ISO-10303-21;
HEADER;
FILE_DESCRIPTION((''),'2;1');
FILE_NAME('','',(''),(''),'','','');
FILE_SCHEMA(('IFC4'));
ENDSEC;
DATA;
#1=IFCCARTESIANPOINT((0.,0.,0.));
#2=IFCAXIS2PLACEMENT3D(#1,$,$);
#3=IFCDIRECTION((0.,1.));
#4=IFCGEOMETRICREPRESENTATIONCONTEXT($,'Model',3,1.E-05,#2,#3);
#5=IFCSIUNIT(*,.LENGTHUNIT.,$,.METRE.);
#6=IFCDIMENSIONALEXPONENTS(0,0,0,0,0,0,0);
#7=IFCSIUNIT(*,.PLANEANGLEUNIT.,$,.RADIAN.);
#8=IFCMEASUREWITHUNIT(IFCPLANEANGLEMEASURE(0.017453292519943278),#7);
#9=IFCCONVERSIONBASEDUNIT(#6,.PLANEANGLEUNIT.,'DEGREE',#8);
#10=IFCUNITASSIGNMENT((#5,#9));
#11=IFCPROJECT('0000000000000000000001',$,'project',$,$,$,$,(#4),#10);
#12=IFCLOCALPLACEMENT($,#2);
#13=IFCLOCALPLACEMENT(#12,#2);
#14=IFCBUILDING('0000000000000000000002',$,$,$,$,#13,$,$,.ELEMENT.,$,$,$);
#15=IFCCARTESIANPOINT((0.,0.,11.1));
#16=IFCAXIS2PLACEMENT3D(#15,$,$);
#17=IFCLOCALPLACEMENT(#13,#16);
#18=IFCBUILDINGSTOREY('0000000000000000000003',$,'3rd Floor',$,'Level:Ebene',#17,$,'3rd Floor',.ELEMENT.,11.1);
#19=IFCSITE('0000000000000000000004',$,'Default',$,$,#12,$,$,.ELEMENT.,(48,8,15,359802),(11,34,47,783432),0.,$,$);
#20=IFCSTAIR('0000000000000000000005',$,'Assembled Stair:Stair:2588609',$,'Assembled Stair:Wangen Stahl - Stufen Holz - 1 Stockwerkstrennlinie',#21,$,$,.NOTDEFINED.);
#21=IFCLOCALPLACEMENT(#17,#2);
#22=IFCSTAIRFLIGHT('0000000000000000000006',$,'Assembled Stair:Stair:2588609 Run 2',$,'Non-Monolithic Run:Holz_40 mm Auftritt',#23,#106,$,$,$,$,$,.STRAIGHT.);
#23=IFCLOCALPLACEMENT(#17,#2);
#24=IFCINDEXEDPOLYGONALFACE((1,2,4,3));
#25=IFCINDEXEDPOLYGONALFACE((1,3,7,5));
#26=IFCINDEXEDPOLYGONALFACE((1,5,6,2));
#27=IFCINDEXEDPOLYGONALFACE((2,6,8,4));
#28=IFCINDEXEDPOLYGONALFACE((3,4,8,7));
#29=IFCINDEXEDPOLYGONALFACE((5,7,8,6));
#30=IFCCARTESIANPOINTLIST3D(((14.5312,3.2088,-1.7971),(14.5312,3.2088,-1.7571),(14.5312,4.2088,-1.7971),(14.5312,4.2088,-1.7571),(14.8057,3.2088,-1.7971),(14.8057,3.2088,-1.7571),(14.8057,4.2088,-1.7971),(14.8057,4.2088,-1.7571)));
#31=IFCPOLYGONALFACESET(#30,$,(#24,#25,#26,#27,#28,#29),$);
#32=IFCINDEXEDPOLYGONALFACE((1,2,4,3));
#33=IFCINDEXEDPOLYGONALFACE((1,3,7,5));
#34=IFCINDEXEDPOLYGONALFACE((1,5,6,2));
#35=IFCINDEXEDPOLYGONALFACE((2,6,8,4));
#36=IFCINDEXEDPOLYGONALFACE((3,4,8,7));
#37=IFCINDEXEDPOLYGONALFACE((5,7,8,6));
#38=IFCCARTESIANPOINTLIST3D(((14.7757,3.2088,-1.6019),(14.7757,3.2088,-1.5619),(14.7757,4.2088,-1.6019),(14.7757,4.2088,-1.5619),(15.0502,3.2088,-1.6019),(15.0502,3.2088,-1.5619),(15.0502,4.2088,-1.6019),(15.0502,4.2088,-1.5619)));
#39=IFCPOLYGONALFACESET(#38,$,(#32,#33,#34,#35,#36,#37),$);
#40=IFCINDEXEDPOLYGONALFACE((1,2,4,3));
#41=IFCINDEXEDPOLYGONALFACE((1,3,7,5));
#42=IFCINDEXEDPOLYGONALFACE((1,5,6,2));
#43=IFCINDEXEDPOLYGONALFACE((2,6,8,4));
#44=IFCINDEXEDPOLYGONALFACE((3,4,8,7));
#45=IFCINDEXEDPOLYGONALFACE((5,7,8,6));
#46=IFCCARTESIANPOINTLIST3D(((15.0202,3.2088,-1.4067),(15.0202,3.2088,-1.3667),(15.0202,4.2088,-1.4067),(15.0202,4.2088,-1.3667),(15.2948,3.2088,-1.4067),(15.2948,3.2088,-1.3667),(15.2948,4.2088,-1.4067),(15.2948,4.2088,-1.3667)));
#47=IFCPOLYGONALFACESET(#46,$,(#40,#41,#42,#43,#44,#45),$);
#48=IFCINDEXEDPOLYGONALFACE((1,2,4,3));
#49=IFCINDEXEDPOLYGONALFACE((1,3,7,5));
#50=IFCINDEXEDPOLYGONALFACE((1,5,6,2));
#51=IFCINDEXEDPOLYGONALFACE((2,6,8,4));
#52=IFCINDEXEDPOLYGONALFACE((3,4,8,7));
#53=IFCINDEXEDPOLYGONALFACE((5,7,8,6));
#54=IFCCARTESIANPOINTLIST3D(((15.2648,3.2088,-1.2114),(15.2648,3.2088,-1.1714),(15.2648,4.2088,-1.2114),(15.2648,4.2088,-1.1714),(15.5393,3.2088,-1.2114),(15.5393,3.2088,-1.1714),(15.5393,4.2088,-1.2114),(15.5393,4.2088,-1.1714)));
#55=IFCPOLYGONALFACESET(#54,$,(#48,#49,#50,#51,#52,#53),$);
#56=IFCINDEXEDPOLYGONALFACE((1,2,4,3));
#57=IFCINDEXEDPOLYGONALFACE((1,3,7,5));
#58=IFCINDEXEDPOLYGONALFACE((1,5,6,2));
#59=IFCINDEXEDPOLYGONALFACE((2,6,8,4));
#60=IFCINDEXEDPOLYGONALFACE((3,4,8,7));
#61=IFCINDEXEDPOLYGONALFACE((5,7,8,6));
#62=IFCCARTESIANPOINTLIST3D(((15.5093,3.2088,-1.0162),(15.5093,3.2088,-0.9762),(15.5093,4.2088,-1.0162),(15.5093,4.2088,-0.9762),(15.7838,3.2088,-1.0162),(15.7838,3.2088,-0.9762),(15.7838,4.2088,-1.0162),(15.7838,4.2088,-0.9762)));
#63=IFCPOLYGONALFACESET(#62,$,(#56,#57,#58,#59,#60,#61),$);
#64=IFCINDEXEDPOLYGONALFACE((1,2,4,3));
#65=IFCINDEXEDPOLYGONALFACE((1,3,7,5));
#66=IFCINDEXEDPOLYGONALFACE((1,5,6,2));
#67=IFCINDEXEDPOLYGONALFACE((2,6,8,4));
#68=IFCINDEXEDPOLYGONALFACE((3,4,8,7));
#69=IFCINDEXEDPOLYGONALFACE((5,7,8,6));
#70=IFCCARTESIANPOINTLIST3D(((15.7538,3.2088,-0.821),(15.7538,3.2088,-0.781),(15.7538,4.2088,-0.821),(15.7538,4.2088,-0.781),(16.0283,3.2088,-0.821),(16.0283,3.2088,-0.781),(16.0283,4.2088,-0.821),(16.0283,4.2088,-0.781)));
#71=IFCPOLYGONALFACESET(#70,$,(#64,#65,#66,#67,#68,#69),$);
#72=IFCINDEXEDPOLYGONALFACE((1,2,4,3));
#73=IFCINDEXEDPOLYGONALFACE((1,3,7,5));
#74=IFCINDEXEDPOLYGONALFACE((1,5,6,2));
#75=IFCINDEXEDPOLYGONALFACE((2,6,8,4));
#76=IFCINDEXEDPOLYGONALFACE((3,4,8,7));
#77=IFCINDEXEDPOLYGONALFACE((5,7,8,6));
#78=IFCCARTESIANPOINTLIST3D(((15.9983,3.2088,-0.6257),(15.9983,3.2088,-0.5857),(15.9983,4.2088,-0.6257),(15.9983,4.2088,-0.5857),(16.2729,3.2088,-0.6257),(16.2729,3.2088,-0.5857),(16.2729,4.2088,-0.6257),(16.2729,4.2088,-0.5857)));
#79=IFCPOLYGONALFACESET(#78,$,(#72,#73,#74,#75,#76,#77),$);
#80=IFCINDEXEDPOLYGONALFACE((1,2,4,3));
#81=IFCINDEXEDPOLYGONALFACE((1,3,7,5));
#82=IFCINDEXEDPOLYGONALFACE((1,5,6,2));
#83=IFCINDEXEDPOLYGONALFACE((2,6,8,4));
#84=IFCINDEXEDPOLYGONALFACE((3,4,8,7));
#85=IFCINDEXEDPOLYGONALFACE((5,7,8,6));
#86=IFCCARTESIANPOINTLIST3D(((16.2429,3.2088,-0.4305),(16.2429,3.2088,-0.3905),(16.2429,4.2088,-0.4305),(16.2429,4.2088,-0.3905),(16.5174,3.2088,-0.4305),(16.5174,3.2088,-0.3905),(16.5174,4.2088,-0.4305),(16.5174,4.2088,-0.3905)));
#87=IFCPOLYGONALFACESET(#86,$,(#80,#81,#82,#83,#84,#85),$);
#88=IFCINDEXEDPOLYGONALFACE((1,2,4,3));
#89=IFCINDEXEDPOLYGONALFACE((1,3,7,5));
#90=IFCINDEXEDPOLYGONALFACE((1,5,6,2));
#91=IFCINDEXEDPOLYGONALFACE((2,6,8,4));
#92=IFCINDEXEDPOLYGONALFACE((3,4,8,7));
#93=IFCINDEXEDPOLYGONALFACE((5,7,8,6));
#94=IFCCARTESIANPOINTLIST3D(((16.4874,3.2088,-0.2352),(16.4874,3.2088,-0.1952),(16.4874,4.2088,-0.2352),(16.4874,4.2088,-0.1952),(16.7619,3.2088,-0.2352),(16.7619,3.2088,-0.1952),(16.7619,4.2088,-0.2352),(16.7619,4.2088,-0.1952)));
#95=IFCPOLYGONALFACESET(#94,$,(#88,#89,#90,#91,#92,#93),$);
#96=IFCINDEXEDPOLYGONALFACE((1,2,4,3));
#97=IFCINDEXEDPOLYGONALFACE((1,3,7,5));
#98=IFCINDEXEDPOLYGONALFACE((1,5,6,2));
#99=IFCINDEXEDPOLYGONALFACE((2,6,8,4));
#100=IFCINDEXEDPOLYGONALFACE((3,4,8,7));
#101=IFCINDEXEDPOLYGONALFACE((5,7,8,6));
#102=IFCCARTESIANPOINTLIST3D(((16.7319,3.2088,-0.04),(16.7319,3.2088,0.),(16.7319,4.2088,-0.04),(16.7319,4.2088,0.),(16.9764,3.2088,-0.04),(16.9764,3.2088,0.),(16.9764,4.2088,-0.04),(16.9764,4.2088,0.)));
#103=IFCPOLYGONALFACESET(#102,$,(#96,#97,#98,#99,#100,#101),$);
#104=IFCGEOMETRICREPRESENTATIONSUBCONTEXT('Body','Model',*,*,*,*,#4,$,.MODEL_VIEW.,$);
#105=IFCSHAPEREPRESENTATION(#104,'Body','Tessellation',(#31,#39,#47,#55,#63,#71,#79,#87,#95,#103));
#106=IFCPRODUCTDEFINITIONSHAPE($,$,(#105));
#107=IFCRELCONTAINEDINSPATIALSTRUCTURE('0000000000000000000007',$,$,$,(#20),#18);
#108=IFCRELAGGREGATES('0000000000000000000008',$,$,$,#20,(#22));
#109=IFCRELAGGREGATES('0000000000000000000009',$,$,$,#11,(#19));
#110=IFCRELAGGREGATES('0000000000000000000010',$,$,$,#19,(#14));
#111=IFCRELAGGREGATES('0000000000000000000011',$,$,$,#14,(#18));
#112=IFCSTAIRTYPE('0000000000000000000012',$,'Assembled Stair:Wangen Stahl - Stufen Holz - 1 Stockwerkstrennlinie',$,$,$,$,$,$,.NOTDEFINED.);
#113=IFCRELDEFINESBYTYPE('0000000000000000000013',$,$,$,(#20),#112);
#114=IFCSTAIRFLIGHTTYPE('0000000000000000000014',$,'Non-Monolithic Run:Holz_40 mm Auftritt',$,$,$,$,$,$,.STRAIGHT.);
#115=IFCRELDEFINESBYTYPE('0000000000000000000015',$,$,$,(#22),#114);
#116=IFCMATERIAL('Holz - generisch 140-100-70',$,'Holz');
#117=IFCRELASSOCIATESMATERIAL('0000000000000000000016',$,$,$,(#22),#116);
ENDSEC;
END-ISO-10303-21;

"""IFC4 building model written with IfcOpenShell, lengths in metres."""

from ifc_helpers import new_model, entity, si_unit, converted_unit, direction, frame, origin, place, context, subcontext, project, spatial, indexed_curve, outline, extrude, material, type_object, element, aggregate, save


model = new_model("IFC4")

# Units and contexts
model_context = context("Model", 3, precision=1e-05, world=origin(), true_north=direction((0.0, 1.0)))
body_context = subcontext(model_context, "Body", "Model", "MODEL_VIEW")
ifc_project = project(units=[si_unit("LENGTHUNIT", "METRE"), converted_unit("PLANEANGLEUNIT", "DEGREE", entity("IfcPlaneAngleMeasure", 0.017453292519943278), si_unit("PLANEANGLEUNIT", "RADIAN"), dimensions=[0, 0, 0, 0, 0, 0, 0])], contexts=[model_context])

# Site, building, storey
site_placement = place(None, origin())
site = spatial("IfcSite", under=ifc_project, at=site_placement, Name="Default", CompositionType="ELEMENT", RefLatitude=(48, 8, 15, 359802), RefLongitude=(11, 34, 47, 783432), RefElevation=0.0)
building_placement = place(site_placement, origin())
building = spatial("IfcBuilding", under=site, at=building_placement, CompositionType="ELEMENT")
storey_placement = place(building_placement, frame((0.0, 0.0, 11.1)))
storey = spatial("IfcBuildingStorey", under=building, at=storey_placement, Name="3rd Floor", ObjectType="Level:Ebene", LongName="3rd Floor", CompositionType="ELEMENT", Elevation=11.1)

# Shared definitions
stair_type = type_object("IfcStairType", Name="Assembled Stair:Wangen Stahl - Stufen Holz - 1 Stockwerkstrennlinie", PredefinedType="NOTDEFINED")

# Shared definitions
ifc_material_1 = material(Name="Holz - generisch 140-100-70", Category="Holz")
stair_flight_type = type_object("IfcStairFlightType", Name="Non-Monolithic Run:Holz_40 mm Auftritt", PredefinedType="STRAIGHT")

# Stair, stair flight
stair_1_placement = place(storey_placement, origin())
stair_1 = element("IfcStair", 1, at=stair_1_placement, inside=storey, type_object=stair_type, Name="Assembled Stair:Stair:2588609", ObjectType="Assembled Stair:Wangen Stahl - Stufen Holz - 1 Stockwerkstrennlinie", PredefinedType="NOTDEFINED")
stair_flight_1_placement = place(stair_1_placement, origin())
stair_flight_1 = element("IfcStairFlight", 2, at=stair_flight_1_placement, type_object=stair_flight_type, material=ifc_material_1, Name="Assembled Stair:Stair:2588609 Run 2", ObjectType="Non-Monolithic Run:Holz_40 mm Auftritt", PredefinedType="STRAIGHT", context=body_context, shape_type="SweptSolid", body=[
    extrude(outline(indexed_curve([(-0.1373, -0.5), (0.1373, -0.5), (0.1373, 0.5), (-0.1373, 0.5), (-0.1373, -0.5)], self_intersect=False)), frame((14.6685, 3.7088, -1.7971), z_axis=(0.0, 0.0, 1.0), x_axis=(-1.0, 0.0, 0.0)), (0.0, 0.0, 1.0), 0.04),
    extrude(outline(indexed_curve([(-0.1373, -0.5), (0.1373, -0.5), (0.1373, 0.5), (-0.1373, 0.5), (-0.1373, -0.5)], self_intersect=False)), frame((14.913, 3.7088, -1.6019), z_axis=(0.0, 0.0, 1.0), x_axis=(-1.0, 0.0, 0.0)), (0.0, 0.0, 1.0), 0.04),
    extrude(outline(indexed_curve([(-0.1373, -0.5), (0.1373, -0.5), (0.1373, 0.5), (-0.1373, 0.5), (-0.1373, -0.5)], self_intersect=False)), frame((15.1575, 3.7088, -1.4067), z_axis=(0.0, 0.0, 1.0), x_axis=(-1.0, 0.0, 0.0)), (0.0, 0.0, 1.0), 0.04),
    extrude(outline(indexed_curve([(-0.1373, -0.5), (0.1373, -0.5), (0.1373, 0.5), (-0.1373, 0.5), (-0.1373, -0.5)], self_intersect=False)), frame((15.402, 3.7088, -1.2114), z_axis=(0.0, 0.0, 1.0), x_axis=(-1.0, 0.0, 0.0)), (0.0, 0.0, 1.0), 0.04),
    extrude(outline(indexed_curve([(-0.1373, -0.5), (0.1373, -0.5), (0.1373, 0.5), (-0.1373, 0.5), (-0.1373, -0.5)], self_intersect=False)), frame((15.6466, 3.7088, -1.0162), z_axis=(0.0, 0.0, 1.0), x_axis=(-1.0, 0.0, 0.0)), (0.0, 0.0, 1.0), 0.04),
    extrude(outline(indexed_curve([(-0.1373, -0.5), (0.1373, -0.5), (0.1373, 0.5), (-0.1373, 0.5), (-0.1373, -0.5)], self_intersect=False)), frame((15.8911, 3.7088, -0.821), z_axis=(0.0, 0.0, 1.0), x_axis=(-1.0, 0.0, 0.0)), (0.0, 0.0, 1.0), 0.04),
    extrude(outline(indexed_curve([(-0.1373, -0.5), (0.1373, -0.5), (0.1373, 0.5), (-0.1373, 0.5), (-0.1373, -0.5)], self_intersect=False)), frame((16.1356, 3.7088, -0.6257), z_axis=(0.0, 0.0, 1.0), x_axis=(-1.0, 0.0, 0.0)), (0.0, 0.0, 1.0), 0.04),
    extrude(outline(indexed_curve([(-0.1373, -0.5), (0.1373, -0.5), (0.1373, 0.5), (-0.1373, 0.5), (-0.1373, -0.5)], self_intersect=False)), frame((16.3801, 3.7088, -0.4305), z_axis=(0.0, 0.0, 1.0), x_axis=(-1.0, 0.0, 0.0)), (0.0, 0.0, 1.0), 0.04),
    extrude(outline(indexed_curve([(-0.1373, -0.5), (0.1373, -0.5), (0.1373, 0.5), (-0.1373, 0.5), (-0.1373, -0.5)], self_intersect=False)), frame((16.6246, 3.7088, -0.2352), z_axis=(0.0, 0.0, 1.0), x_axis=(-1.0, 0.0, 0.0)), (0.0, 0.0, 1.0), 0.04),
    extrude(outline(indexed_curve([(-0.1223, -0.5), (0.1223, -0.5), (0.1223, 0.5), (-0.1223, 0.5), (-0.1223, -0.5)], self_intersect=False)), frame((16.8542, 3.7088, -0.04), z_axis=(0.0, 0.0, 1.0), x_axis=(-1.0, 0.0, 0.0)), (0.0, 0.0, 1.0), 0.04),
])
aggregate(stair_1, [stair_flight_1])

save(model, "model.ifc")
